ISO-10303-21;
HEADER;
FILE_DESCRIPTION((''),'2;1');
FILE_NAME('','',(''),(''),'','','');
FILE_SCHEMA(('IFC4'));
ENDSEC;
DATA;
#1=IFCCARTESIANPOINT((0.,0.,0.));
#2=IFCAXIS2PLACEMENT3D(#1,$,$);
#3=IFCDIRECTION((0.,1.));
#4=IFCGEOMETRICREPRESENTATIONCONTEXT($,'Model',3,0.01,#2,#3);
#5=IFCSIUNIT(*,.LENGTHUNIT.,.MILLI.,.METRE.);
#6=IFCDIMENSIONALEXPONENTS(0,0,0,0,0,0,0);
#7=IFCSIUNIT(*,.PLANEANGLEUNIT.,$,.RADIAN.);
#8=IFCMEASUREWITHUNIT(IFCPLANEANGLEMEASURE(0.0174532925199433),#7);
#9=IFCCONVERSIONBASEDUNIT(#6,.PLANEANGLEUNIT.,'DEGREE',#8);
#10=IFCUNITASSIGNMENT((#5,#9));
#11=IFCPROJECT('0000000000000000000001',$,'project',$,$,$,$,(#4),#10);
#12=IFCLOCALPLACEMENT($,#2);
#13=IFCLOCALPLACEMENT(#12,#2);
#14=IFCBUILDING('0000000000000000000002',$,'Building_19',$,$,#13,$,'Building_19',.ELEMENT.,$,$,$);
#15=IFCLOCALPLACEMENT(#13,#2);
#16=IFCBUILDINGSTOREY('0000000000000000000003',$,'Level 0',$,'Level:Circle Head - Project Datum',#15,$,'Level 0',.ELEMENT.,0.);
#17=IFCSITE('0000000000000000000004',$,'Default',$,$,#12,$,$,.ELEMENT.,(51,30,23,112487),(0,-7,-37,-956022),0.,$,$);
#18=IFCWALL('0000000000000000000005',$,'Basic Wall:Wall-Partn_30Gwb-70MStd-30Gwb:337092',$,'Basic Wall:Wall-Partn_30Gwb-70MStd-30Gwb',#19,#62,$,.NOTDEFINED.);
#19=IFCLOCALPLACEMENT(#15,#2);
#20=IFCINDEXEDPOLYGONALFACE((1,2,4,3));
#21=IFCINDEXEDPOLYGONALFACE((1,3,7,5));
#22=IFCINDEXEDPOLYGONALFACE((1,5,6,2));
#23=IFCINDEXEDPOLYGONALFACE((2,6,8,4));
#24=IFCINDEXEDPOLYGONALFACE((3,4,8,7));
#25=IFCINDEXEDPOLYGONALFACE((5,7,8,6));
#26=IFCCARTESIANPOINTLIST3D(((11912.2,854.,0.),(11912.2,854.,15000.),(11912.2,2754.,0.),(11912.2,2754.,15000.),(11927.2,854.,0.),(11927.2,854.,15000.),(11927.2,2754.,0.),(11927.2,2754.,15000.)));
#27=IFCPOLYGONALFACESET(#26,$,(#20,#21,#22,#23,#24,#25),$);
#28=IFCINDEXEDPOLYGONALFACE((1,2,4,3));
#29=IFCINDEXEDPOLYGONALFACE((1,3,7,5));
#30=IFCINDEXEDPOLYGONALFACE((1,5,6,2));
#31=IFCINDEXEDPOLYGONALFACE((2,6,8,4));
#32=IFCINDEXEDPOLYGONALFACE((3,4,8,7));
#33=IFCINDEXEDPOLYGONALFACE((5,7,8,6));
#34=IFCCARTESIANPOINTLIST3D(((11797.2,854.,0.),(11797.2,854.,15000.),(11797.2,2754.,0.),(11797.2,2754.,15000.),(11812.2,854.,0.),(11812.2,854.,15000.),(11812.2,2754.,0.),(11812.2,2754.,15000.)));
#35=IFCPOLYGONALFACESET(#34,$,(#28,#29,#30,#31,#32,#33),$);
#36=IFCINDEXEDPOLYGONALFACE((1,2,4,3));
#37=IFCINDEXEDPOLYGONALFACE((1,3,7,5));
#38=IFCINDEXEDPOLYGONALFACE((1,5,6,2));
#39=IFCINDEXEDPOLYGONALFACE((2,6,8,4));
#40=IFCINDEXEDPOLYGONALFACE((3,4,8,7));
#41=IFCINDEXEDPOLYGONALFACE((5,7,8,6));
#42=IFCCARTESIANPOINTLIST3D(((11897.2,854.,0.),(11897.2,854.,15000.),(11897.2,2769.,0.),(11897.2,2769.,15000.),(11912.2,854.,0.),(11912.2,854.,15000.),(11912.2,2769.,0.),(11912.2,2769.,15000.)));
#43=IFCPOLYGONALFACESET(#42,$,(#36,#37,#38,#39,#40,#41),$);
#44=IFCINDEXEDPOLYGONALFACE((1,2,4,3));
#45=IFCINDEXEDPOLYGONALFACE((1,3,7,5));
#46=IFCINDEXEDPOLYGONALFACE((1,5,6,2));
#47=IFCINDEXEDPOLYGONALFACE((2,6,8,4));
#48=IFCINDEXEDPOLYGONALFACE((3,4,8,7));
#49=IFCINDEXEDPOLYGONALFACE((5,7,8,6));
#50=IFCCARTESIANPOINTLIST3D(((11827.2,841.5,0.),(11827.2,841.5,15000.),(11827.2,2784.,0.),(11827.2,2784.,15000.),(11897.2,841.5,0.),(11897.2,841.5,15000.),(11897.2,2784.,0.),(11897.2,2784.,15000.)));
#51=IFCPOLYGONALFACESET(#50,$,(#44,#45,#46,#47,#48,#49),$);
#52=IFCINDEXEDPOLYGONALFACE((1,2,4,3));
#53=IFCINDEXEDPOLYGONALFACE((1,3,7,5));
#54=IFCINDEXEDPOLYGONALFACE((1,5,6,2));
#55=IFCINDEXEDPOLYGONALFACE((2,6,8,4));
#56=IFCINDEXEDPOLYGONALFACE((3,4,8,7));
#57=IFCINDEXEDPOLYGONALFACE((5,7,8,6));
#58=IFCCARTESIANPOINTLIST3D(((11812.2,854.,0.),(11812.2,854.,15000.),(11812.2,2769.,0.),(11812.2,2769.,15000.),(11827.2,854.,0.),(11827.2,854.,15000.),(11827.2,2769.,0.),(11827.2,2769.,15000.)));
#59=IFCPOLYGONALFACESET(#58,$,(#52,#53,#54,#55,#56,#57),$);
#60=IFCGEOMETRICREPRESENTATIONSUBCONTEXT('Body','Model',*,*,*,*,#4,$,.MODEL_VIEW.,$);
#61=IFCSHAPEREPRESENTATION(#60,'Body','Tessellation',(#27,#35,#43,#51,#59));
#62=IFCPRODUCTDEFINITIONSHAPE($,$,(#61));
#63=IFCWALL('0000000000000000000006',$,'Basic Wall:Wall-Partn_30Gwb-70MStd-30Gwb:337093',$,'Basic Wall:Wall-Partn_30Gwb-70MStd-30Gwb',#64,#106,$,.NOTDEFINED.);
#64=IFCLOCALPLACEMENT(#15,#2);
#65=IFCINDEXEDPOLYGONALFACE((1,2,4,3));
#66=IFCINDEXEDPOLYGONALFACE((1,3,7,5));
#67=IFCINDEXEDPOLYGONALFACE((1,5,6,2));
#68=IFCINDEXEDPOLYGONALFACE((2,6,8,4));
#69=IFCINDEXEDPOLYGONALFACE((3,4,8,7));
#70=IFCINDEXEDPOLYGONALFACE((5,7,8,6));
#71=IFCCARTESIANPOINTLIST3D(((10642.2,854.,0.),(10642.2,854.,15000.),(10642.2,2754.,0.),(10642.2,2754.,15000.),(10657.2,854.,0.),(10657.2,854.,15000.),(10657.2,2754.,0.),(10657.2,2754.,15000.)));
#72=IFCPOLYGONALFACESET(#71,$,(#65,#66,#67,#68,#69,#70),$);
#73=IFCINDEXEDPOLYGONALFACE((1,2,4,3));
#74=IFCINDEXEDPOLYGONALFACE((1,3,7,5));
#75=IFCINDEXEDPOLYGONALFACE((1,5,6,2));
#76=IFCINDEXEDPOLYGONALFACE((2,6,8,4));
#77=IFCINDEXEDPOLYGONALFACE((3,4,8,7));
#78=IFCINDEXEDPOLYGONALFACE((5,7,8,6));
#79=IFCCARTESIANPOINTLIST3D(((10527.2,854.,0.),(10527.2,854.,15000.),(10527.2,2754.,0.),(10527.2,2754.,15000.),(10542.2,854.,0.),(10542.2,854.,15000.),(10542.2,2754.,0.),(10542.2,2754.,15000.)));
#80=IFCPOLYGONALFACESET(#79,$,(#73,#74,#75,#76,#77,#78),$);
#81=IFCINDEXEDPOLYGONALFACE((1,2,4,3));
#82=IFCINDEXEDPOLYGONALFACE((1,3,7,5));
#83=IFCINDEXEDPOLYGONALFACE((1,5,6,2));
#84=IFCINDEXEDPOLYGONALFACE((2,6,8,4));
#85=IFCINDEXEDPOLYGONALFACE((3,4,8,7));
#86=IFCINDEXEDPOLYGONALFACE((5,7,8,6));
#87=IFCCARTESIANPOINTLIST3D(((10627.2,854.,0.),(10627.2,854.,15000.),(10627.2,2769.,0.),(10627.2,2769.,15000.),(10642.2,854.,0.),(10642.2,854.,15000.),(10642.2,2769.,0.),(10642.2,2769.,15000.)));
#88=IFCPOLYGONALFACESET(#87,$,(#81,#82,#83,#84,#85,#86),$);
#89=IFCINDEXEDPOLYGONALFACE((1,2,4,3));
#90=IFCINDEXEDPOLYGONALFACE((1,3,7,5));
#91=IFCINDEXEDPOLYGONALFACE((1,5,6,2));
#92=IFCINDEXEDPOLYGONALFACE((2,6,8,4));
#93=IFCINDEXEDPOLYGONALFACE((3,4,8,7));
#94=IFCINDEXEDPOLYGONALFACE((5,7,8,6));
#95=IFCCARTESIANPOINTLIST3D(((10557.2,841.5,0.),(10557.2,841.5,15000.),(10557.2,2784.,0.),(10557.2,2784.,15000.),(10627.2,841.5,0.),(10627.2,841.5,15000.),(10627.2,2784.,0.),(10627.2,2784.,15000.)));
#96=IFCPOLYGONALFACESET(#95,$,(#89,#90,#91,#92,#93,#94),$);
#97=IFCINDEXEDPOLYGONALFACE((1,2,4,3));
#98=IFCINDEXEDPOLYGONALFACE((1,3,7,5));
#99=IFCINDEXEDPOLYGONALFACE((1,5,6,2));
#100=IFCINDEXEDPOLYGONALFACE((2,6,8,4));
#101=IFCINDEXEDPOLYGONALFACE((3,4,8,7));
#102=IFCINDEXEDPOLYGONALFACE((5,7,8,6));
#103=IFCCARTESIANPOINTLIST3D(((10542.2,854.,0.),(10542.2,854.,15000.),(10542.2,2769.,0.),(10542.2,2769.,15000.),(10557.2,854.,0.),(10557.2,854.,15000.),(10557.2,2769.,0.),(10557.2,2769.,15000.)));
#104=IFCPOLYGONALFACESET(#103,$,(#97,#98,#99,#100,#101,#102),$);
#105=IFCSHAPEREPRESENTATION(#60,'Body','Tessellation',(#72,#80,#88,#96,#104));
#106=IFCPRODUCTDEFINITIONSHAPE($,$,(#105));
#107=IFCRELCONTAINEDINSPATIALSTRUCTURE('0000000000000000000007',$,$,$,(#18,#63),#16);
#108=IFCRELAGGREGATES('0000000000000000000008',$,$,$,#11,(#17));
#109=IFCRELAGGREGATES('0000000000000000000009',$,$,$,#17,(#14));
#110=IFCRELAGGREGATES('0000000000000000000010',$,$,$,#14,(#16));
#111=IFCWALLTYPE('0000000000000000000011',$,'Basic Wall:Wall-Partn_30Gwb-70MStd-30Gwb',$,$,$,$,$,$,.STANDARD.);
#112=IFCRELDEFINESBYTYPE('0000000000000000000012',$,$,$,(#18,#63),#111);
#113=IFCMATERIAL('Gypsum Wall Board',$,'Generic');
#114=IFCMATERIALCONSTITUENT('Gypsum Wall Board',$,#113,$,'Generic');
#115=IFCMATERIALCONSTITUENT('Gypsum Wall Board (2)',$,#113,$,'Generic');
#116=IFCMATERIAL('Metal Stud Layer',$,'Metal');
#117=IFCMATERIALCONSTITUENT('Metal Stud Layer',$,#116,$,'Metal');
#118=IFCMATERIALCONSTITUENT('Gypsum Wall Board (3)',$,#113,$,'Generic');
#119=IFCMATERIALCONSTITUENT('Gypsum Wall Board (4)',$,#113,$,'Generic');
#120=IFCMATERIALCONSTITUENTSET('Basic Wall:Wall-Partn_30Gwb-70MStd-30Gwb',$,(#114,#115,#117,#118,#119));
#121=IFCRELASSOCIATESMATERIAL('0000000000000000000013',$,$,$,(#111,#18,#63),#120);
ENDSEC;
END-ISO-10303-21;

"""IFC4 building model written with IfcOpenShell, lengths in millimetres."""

from ifc_helpers import new_model, entity, si_unit, converted_unit, direction, frame, origin, place, context, subcontext, project, spatial, indexed_curve, outline, extrude, material, constituent, constituent_set, type_object, element, save


model = new_model("IFC4")

# Units and contexts
model_context = context("Model", 3, precision=0.01, world=origin(), true_north=direction((0.0, 1.0)))
body_context = subcontext(model_context, "Body", "Model", "MODEL_VIEW")
ifc_project = project(units=[si_unit("LENGTHUNIT", "METRE", prefix="MILLI"), converted_unit("PLANEANGLEUNIT", "DEGREE", entity("IfcPlaneAngleMeasure", 0.0174532925199433), si_unit("PLANEANGLEUNIT", "RADIAN"), dimensions=[0, 0, 0, 0, 0, 0, 0])], contexts=[model_context])

# Site, building, storey
site_placement = place(None, origin())
site = spatial("IfcSite", under=ifc_project, at=site_placement, Name="Default", CompositionType="ELEMENT", RefLatitude=(51, 30, 23, 112487), RefLongitude=(0, -7, -37, -956022), RefElevation=0.0)
building_placement = place(site_placement, origin())
building = spatial("IfcBuilding", under=site, at=building_placement, Name="Building_19", LongName="Building_19", CompositionType="ELEMENT")
storey_placement = place(building_placement, origin())
storey = spatial("IfcBuildingStorey", under=building, at=storey_placement, Name="Level 0", ObjectType="Level:Circle Head - Project Datum", LongName="Level 0", CompositionType="ELEMENT", Elevation=0.0)

# Shared definitions
ifc_material_1 = material(Name="Gypsum Wall Board", Category="Generic")
ifc_constituent_1 = constituent(ifc_material_1, Name="Gypsum Wall Board", Category="Generic")
ifc_constituent_2 = constituent(ifc_material_1, Name="Gypsum Wall Board (2)", Category="Generic")
ifc_material_2 = material(Name="Metal Stud Layer", Category="Metal")
ifc_constituent_3 = constituent(ifc_material_2, Name="Metal Stud Layer", Category="Metal")
ifc_constituent_4 = constituent(ifc_material_1, Name="Gypsum Wall Board (3)", Category="Generic")
ifc_constituent_5 = constituent(ifc_material_1, Name="Gypsum Wall Board (4)", Category="Generic")
ifc_constituent_set_1 = constituent_set(constituents=[ifc_constituent_1, ifc_constituent_2, ifc_constituent_3, ifc_constituent_4, ifc_constituent_5], Name="Basic Wall:Wall-Partn_30Gwb-70MStd-30Gwb")
wall_type_1 = type_object("IfcWallType", Name="Basic Wall:Wall-Partn_30Gwb-70MStd-30Gwb", PredefinedType="STANDARD", material=ifc_constituent_set_1)

# Walls
wall_1_placement = place(storey_placement, frame((11862.2, 2754.0, 0.0), z_axis=(0.0, 0.0, 1.0), x_axis=(0.0, -1.0, 0.0)))
element("IfcWall", 1, at=wall_1_placement, inside=storey, type_object=wall_type_1, material=ifc_constituent_set_1, Name="Basic Wall:Wall-Partn_30Gwb-70MStd-30Gwb:337092", ObjectType="Basic Wall:Wall-Partn_30Gwb-70MStd-30Gwb", PredefinedType="NOTDEFINED", context=body_context, shape_type="SweptSolid", body=[
    extrude(outline(indexed_curve([(-7.5, -950.0), (7.5, -950.0), (7.5, 950.0), (-7.5, 950.0), (-7.5, -950.0)], self_intersect=False)), frame((950.0, 57.5, 0.0), z_axis=(0.0, 0.0, 1.0), x_axis=(0.0, -1.0, 0.0)), (0.0, 0.0, 1.0), 15000.0),
    extrude(outline(indexed_curve([(-7.5, -950.0), (7.5, -950.0), (7.5, 950.0), (-7.5, 950.0), (-7.5, -950.0)], self_intersect=False)), frame((950.0, -57.5, 0.0), z_axis=(0.0, 0.0, 1.0), x_axis=(0.0, 1.0, 0.0)), (0.0, 0.0, 1.0), 15000.0),
    extrude(outline(indexed_curve([(-957.5, -7.5), (957.5, -7.5), (957.5, 7.5), (-957.5, 7.5), (-957.5, -7.5)], self_intersect=False)), frame((942.5, 42.5, 0.0)), (0.0, 0.0, 1.0), 15000.0),
    extrude(outline(indexed_curve([(-971.3, -35.0), (971.3, -35.0), (971.3, 35.0), (-971.3, 35.0), (-971.3, -35.0)], self_intersect=False)), frame((941.3, 0.0, 0.0)), (0.0, 0.0, 1.0), 15000.0),
    extrude(outline(indexed_curve([(-957.5, -7.5), (957.5, -7.5), (957.5, 7.5), (-957.5, 7.5), (-957.5, -7.5)], self_intersect=False)), frame((942.5, -42.5, 0.0)), (0.0, 0.0, 1.0), 15000.0),
])
wall_2_placement = place(storey_placement, frame((10592.2, 2754.0, 0.0), z_axis=(0.0, 0.0, 1.0), x_axis=(0.0, -1.0, 0.0)))
element("IfcWall", 2, at=wall_2_placement, inside=storey, type_object=wall_type_1, material=ifc_constituent_set_1, Name="Basic Wall:Wall-Partn_30Gwb-70MStd-30Gwb:337093", ObjectType="Basic Wall:Wall-Partn_30Gwb-70MStd-30Gwb", PredefinedType="NOTDEFINED", context=body_context, shape_type="SweptSolid", body=[
    extrude(outline(indexed_curve([(-7.5, -950.0), (7.5, -950.0), (7.5, 950.0), (-7.5, 950.0), (-7.5, -950.0)], self_intersect=False)), frame((950.0, 57.5, 0.0), z_axis=(0.0, 0.0, 1.0), x_axis=(0.0, -1.0, 0.0)), (0.0, 0.0, 1.0), 15000.0),
    extrude(outline(indexed_curve([(-7.5, -950.0), (7.5, -950.0), (7.5, 950.0), (-7.5, 950.0), (-7.5, -950.0)], self_intersect=False)), frame((950.0, -57.5, 0.0), z_axis=(0.0, 0.0, 1.0), x_axis=(0.0, 1.0, 0.0)), (0.0, 0.0, 1.0), 15000.0),
    extrude(outline(indexed_curve([(-957.5, -7.5), (957.5, -7.5), (957.5, 7.5), (-957.5, 7.5), (-957.5, -7.5)], self_intersect=False)), frame((942.5, 42.5, 0.0)), (0.0, 0.0, 1.0), 15000.0),
    extrude(outline(indexed_curve([(-971.2, -35.0), (971.2, -35.0), (971.2, 35.0), (-971.2, 35.0), (-971.2, -35.0)], self_intersect=False)), frame((941.2, 0.0, 0.0)), (0.0, 0.0, 1.0), 15000.0),
    extrude(outline(indexed_curve([(-957.5, -7.5), (957.5, -7.5), (957.5, 7.5), (-957.5, 7.5), (-957.5, -7.5)], self_intersect=False)), frame((942.5, -42.5, 0.0)), (0.0, 0.0, 1.0), 15000.0),
])

save(model, "model.ifc")
